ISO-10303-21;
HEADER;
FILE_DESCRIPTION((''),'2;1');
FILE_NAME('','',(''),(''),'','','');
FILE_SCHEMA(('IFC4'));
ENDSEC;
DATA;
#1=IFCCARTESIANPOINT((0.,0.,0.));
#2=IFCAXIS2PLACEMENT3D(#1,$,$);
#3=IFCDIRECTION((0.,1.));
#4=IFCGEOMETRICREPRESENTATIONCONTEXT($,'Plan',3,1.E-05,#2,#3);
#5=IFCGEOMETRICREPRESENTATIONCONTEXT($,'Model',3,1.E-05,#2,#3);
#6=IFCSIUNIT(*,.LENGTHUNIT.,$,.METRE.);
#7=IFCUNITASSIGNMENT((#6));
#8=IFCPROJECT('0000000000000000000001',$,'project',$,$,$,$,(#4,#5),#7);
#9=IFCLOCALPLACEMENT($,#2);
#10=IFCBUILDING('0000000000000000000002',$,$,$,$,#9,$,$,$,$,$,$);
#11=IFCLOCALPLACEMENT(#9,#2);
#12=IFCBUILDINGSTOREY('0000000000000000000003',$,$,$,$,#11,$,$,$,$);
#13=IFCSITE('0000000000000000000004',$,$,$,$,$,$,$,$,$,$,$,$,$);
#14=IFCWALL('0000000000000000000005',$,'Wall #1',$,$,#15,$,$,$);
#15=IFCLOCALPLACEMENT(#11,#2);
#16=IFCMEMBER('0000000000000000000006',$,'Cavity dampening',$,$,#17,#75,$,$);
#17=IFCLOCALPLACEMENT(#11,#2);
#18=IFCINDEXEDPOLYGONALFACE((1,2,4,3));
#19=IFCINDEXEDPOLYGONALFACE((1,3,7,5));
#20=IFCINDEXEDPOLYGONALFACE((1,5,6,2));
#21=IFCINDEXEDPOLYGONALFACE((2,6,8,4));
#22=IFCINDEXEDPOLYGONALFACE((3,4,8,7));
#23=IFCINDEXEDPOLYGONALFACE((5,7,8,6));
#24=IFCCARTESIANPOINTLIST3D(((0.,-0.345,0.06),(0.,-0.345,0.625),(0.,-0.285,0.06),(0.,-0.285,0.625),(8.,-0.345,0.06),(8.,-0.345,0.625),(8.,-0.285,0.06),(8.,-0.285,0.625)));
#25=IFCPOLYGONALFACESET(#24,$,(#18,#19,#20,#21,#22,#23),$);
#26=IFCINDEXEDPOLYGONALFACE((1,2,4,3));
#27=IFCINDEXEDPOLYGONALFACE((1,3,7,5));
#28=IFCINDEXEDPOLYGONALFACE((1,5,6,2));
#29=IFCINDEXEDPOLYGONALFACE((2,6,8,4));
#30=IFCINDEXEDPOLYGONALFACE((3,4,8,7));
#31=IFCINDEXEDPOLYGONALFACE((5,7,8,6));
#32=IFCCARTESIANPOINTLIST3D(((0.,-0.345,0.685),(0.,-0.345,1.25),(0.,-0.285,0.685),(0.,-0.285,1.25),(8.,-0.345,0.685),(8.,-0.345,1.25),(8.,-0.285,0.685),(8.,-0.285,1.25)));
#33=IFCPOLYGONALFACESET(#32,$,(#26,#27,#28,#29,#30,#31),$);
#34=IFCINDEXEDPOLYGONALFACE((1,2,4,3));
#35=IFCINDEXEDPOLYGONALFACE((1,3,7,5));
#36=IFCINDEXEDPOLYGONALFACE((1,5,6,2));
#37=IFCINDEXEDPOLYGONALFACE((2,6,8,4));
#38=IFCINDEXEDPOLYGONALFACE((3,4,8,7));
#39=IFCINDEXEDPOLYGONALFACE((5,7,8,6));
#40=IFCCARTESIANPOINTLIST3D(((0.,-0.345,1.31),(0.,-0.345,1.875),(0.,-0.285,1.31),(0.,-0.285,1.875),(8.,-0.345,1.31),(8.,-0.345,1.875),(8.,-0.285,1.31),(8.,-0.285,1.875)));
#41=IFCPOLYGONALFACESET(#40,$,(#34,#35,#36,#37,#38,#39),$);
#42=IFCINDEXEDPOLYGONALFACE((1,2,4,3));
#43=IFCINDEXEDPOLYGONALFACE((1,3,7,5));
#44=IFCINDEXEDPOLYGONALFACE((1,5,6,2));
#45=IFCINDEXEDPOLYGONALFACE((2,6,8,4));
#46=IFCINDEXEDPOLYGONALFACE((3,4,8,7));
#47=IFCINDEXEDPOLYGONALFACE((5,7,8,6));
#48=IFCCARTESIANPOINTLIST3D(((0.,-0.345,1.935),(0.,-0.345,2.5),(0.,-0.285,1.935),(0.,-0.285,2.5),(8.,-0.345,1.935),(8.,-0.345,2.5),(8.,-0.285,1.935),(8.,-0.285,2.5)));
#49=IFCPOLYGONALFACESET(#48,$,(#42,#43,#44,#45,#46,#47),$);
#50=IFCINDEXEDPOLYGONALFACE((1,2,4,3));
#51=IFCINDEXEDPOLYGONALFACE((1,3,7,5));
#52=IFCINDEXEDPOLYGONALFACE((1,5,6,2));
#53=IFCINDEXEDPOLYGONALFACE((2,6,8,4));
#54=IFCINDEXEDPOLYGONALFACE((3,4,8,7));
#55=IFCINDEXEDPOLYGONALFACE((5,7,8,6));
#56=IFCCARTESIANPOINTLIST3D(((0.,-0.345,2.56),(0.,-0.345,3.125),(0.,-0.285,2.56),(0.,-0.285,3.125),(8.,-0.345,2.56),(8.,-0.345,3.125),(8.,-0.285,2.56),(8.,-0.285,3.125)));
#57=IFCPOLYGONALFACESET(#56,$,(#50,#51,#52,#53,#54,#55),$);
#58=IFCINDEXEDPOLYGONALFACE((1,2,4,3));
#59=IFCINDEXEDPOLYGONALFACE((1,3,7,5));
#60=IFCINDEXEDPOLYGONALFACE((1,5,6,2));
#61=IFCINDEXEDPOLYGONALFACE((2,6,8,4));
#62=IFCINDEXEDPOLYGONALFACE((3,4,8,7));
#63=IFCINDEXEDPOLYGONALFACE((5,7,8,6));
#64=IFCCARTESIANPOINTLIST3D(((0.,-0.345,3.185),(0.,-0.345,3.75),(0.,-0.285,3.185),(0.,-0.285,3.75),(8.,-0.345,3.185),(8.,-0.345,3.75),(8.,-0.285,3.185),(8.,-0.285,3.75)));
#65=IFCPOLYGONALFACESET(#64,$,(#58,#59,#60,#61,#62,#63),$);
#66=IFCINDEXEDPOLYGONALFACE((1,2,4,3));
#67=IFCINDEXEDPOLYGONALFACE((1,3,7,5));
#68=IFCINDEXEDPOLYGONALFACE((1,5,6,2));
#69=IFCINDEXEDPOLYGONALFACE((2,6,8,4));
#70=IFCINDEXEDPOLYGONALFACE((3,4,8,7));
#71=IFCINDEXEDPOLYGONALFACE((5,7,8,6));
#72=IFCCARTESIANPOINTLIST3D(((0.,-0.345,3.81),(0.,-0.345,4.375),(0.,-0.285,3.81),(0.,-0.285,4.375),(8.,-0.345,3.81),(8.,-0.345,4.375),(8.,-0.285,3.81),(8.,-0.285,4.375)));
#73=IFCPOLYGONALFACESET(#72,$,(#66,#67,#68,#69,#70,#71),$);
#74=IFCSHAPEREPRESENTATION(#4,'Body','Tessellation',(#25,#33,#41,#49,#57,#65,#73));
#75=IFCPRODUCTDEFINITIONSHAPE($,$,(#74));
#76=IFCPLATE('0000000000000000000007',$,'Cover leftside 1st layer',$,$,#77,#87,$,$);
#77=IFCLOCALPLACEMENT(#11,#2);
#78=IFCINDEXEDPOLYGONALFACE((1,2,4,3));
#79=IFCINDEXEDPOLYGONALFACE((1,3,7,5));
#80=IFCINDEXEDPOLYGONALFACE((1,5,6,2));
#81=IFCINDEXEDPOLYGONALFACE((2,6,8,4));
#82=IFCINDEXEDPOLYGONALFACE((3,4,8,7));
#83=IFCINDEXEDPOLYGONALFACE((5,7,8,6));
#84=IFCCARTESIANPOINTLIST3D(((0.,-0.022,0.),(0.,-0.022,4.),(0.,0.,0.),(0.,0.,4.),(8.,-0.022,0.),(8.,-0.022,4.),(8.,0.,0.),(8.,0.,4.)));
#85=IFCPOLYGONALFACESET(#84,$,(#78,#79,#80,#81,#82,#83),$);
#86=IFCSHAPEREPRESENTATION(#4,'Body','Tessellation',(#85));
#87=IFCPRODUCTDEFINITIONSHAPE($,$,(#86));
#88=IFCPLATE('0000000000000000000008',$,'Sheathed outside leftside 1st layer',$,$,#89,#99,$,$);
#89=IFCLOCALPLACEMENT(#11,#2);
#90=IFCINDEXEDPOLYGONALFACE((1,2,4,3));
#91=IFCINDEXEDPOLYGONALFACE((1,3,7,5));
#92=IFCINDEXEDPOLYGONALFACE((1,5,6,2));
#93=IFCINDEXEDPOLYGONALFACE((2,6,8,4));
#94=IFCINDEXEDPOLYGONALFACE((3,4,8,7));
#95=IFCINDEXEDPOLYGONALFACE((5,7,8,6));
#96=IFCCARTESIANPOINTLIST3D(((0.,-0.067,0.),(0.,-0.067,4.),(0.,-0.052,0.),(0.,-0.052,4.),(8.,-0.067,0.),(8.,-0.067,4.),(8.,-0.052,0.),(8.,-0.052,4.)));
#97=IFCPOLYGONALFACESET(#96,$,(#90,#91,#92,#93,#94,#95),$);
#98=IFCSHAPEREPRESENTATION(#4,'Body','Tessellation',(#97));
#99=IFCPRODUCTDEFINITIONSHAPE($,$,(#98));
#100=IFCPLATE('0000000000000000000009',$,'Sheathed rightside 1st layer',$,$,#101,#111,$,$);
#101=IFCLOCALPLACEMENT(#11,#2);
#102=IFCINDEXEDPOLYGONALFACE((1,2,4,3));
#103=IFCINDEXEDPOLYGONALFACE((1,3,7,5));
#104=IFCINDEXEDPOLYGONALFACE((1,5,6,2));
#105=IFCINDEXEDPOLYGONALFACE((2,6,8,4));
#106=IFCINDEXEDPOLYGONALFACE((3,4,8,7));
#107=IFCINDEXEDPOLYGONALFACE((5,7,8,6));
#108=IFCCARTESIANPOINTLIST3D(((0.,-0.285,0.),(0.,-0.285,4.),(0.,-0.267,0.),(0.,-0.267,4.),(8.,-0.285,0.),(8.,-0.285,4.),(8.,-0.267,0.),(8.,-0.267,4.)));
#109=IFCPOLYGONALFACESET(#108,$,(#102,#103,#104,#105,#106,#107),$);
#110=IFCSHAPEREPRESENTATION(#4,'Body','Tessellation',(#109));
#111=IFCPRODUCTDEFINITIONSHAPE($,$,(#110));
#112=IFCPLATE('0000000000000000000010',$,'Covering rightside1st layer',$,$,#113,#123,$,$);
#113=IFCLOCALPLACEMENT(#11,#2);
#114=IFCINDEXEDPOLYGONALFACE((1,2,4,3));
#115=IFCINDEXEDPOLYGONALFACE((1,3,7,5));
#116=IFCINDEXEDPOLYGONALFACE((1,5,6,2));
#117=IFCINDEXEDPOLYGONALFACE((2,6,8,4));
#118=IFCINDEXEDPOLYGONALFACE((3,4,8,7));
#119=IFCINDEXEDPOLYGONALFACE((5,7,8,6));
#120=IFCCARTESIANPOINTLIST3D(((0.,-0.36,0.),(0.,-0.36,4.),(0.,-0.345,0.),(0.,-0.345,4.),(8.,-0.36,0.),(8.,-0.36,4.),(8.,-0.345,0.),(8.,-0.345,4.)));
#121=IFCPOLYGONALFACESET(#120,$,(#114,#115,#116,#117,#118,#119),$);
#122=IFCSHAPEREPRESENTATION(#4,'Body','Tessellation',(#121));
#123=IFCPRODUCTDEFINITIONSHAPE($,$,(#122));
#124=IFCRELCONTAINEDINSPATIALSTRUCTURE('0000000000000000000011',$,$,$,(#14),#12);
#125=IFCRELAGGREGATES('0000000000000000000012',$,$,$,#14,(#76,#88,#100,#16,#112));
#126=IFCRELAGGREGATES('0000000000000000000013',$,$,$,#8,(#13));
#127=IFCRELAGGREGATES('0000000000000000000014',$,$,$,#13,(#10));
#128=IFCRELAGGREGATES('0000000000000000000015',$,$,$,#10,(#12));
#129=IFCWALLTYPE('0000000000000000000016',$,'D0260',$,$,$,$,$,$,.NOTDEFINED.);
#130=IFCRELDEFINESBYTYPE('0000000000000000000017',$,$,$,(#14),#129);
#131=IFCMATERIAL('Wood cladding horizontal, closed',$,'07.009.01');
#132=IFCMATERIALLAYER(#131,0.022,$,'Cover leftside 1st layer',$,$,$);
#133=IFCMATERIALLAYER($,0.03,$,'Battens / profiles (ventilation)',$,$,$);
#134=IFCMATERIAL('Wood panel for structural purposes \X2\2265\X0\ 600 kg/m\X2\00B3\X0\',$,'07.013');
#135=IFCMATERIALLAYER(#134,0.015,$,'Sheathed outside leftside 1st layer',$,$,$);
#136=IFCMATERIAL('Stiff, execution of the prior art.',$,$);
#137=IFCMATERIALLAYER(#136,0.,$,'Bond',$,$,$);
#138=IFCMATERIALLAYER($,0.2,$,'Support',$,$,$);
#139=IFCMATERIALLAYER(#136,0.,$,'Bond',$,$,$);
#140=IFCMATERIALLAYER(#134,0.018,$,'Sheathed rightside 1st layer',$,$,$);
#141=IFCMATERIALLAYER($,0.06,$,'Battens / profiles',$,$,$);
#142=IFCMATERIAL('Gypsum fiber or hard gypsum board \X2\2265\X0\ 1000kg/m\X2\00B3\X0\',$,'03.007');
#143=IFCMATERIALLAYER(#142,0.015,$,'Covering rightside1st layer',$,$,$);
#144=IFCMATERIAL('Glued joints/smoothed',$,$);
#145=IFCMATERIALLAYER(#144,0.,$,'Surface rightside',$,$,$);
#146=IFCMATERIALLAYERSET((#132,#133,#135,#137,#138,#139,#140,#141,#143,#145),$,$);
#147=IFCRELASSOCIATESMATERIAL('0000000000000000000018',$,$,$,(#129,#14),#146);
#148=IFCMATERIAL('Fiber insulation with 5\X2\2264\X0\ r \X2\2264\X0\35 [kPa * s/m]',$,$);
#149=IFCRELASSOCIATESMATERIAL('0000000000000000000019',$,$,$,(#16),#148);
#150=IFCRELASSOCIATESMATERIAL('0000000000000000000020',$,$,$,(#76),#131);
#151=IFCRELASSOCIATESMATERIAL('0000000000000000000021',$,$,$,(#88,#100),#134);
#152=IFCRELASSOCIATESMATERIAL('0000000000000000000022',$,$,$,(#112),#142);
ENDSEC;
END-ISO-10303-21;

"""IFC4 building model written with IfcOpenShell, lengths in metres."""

from ifc_helpers import new_model, si_unit, direction, frame, frame_2d, origin, origin_with_axes, place, context, project, spatial, rectangle, extrude, material, layer, layer_set, type_object, element, aggregate, save


model = new_model("IFC4")

# Units and contexts
plan_context = context("Plan", 3, precision=1e-05, world=origin(), true_north=direction((0.0, 1.0)))
model_context = context("Model", 3, precision=1e-05, world=origin(), true_north=direction((0.0, 1.0)))
ifc_project = project(units=[si_unit("LENGTHUNIT", "METRE")], contexts=[plan_context, model_context])

# Site, building, storey
site = spatial("IfcSite", under=ifc_project)
building_placement = place(None, origin())
building = spatial("IfcBuilding", under=site, at=building_placement)
storey_placement = place(building_placement, origin())
storey = spatial("IfcBuildingStorey", under=building, at=storey_placement)

# Wall, member, plates
ifc_material_1 = material(Name="Wood cladding horizontal, closed", Category="07.009.01")
ifc_layer_1 = layer(ifc_material_1, 0.022, Name="Cover leftside 1st layer")
ifc_layer_2 = layer(None, 0.03, Name="Battens / profiles (ventilation)")
ifc_material_2 = material(Name="Wood panel for structural purposes ≥ 600 kg/m³", Category="07.013")
ifc_layer_3 = layer(ifc_material_2, 0.015, Name="Sheathed outside leftside 1st layer")
ifc_material_3 = material(Name="Stiff, execution of the prior art.")
ifc_layer_4 = layer(ifc_material_3, 0.0, Name="Bond")
ifc_layer_5 = layer(None, 0.2, Name="Support")
ifc_layer_6 = layer(ifc_material_3, 0.0, Name="Bond")
ifc_layer_7 = layer(ifc_material_2, 0.018, Name="Sheathed rightside 1st layer")
ifc_layer_8 = layer(None, 0.06, Name="Battens / profiles")
ifc_material_4 = material(Name="Gypsum fiber or hard gypsum board ≥ 1000kg/m³", Category="03.007")
ifc_layer_9 = layer(ifc_material_4, 0.015, Name="Covering rightside1st layer")
ifc_material_5 = material(Name="Glued joints/smoothed")
ifc_layer_10 = layer(ifc_material_5, 0.0, Name="Surface rightside")
ifc_layer_set = layer_set([ifc_layer_1, ifc_layer_2, ifc_layer_3, ifc_layer_4, ifc_layer_5, ifc_layer_6, ifc_layer_7, ifc_layer_8, ifc_layer_9, ifc_layer_10])
wall_type = type_object("IfcWallType", Name="D0260", PredefinedType="NOTDEFINED", material=ifc_layer_set)
wall_placement = place(None, frame((0.0, 0.0, 0.0), z_axis=(0.0, -1.0, 0.0), x_axis=(1.0, 0.0, 0.0)))
wall = element("IfcWall", 1, at=wall_placement, inside=storey, type_object=wall_type, material=ifc_layer_set, Name="Wall #1")
ifc_material_6 = material(Name="Fiber insulation with 5≤ r ≤35 [kPa * s/m]")
member_1_placement = place(wall_placement, origin())
member_1 = element("IfcMember", 2, at=member_1_placement, material=ifc_material_6, Name="Cavity dampening", context=plan_context, shape_type="SweptSolid", body=[
    extrude(rectangle(XDim=0.565, YDim=0.06, at=frame_2d((0.2825, 0.03), x_axis=(1.0, 0.0))), frame((0.0, 0.06, 0.285), z_axis=(1.0, 0.0, 0.0), x_axis=(0.0, 1.0, 0.0)), (0.0, 0.0, 1.0), 8.0),
    extrude(rectangle(XDim=0.565, YDim=0.06, at=frame_2d((0.2825, 0.03), x_axis=(1.0, 0.0))), frame((0.0, 0.685, 0.285), z_axis=(1.0, 0.0, 0.0), x_axis=(0.0, 1.0, 0.0)), (0.0, 0.0, 1.0), 8.0),
    extrude(rectangle(XDim=0.565, YDim=0.06, at=frame_2d((0.2825, 0.03), x_axis=(1.0, 0.0))), frame((0.0, 1.31, 0.285), z_axis=(1.0, 0.0, 0.0), x_axis=(0.0, 1.0, 0.0)), (0.0, 0.0, 1.0), 8.0),
    extrude(rectangle(XDim=0.565, YDim=0.06, at=frame_2d((0.2825, 0.03), x_axis=(1.0, 0.0))), frame((0.0, 1.935, 0.285), z_axis=(1.0, 0.0, 0.0), x_axis=(0.0, 1.0, 0.0)), (0.0, 0.0, 1.0), 8.0),
    extrude(rectangle(XDim=0.565, YDim=0.06, at=frame_2d((0.2825, 0.03), x_axis=(1.0, 0.0))), frame((0.0, 2.56, 0.285), z_axis=(1.0, 0.0, 0.0), x_axis=(0.0, 1.0, 0.0)), (0.0, 0.0, 1.0), 8.0),
    extrude(rectangle(XDim=0.565, YDim=0.06, at=frame_2d((0.2825, 0.03), x_axis=(1.0, 0.0))), frame((0.0, 3.185, 0.285), z_axis=(1.0, 0.0, 0.0), x_axis=(0.0, 1.0, 0.0)), (0.0, 0.0, 1.0), 8.0),
    extrude(rectangle(XDim=0.565, YDim=0.06, at=frame_2d((0.2825, 0.03), x_axis=(1.0, 0.0))), frame((0.0, 3.81, 0.285), z_axis=(1.0, 0.0, 0.0), x_axis=(0.0, 1.0, 0.0)), (0.0, 0.0, 1.0), 8.0),
])
plate_1_placement = place(wall_placement, origin())
plate_1 = element("IfcPlate", 3, at=plate_1_placement, material=ifc_material_1, Name="Cover leftside 1st layer", context=plan_context, shape_type="SweptSolid", body=[
    extrude(rectangle(XDim=8.0, YDim=4.0, at=frame_2d((4.0, 2.0), x_axis=(1.0, 0.0))), origin_with_axes(), (0.0, 0.0, 1.0), 0.022),
])
plate_2_placement = place(wall_placement, origin())
plate_2 = element("IfcPlate", 4, at=plate_2_placement, material=ifc_material_2, Name="Sheathed outside leftside 1st layer", context=plan_context, shape_type="SweptSolid", body=[
    extrude(rectangle(XDim=8.0, YDim=4.0, at=frame_2d((4.0, 2.0), x_axis=(1.0, 0.0))), frame((0.0, 0.0, 0.052), z_axis=(0.0, 0.0, 1.0), x_axis=(1.0, 0.0, 0.0)), (0.0, 0.0, 1.0), 0.015),
])
plate_3_placement = place(wall_placement, origin())
plate_3 = element("IfcPlate", 5, at=plate_3_placement, material=ifc_material_2, Name="Sheathed rightside 1st layer", context=plan_context, shape_type="SweptSolid", body=[
    extrude(rectangle(XDim=8.0, YDim=4.0, at=frame_2d((4.0, 2.0), x_axis=(1.0, 0.0))), frame((0.0, 0.0, 0.267), z_axis=(0.0, 0.0, 1.0), x_axis=(1.0, 0.0, 0.0)), (0.0, 0.0, 1.0), 0.018),
])
plate_4_placement = place(wall_placement, origin())
plate_4 = element("IfcPlate", 6, at=plate_4_placement, material=ifc_material_4, Name="Covering rightside1st layer", context=plan_context, shape_type="SweptSolid", body=[
    extrude(rectangle(XDim=8.0, YDim=4.0, at=frame_2d((4.0, 2.0), x_axis=(1.0, 0.0))), frame((0.0, 0.0, 0.345), z_axis=(0.0, 0.0, 1.0), x_axis=(1.0, 0.0, 0.0)), (0.0, 0.0, 1.0), 0.015),
])
aggregate(wall, [plate_1, plate_2, plate_3, member_1, plate_4])

save(model, "model.ifc")
